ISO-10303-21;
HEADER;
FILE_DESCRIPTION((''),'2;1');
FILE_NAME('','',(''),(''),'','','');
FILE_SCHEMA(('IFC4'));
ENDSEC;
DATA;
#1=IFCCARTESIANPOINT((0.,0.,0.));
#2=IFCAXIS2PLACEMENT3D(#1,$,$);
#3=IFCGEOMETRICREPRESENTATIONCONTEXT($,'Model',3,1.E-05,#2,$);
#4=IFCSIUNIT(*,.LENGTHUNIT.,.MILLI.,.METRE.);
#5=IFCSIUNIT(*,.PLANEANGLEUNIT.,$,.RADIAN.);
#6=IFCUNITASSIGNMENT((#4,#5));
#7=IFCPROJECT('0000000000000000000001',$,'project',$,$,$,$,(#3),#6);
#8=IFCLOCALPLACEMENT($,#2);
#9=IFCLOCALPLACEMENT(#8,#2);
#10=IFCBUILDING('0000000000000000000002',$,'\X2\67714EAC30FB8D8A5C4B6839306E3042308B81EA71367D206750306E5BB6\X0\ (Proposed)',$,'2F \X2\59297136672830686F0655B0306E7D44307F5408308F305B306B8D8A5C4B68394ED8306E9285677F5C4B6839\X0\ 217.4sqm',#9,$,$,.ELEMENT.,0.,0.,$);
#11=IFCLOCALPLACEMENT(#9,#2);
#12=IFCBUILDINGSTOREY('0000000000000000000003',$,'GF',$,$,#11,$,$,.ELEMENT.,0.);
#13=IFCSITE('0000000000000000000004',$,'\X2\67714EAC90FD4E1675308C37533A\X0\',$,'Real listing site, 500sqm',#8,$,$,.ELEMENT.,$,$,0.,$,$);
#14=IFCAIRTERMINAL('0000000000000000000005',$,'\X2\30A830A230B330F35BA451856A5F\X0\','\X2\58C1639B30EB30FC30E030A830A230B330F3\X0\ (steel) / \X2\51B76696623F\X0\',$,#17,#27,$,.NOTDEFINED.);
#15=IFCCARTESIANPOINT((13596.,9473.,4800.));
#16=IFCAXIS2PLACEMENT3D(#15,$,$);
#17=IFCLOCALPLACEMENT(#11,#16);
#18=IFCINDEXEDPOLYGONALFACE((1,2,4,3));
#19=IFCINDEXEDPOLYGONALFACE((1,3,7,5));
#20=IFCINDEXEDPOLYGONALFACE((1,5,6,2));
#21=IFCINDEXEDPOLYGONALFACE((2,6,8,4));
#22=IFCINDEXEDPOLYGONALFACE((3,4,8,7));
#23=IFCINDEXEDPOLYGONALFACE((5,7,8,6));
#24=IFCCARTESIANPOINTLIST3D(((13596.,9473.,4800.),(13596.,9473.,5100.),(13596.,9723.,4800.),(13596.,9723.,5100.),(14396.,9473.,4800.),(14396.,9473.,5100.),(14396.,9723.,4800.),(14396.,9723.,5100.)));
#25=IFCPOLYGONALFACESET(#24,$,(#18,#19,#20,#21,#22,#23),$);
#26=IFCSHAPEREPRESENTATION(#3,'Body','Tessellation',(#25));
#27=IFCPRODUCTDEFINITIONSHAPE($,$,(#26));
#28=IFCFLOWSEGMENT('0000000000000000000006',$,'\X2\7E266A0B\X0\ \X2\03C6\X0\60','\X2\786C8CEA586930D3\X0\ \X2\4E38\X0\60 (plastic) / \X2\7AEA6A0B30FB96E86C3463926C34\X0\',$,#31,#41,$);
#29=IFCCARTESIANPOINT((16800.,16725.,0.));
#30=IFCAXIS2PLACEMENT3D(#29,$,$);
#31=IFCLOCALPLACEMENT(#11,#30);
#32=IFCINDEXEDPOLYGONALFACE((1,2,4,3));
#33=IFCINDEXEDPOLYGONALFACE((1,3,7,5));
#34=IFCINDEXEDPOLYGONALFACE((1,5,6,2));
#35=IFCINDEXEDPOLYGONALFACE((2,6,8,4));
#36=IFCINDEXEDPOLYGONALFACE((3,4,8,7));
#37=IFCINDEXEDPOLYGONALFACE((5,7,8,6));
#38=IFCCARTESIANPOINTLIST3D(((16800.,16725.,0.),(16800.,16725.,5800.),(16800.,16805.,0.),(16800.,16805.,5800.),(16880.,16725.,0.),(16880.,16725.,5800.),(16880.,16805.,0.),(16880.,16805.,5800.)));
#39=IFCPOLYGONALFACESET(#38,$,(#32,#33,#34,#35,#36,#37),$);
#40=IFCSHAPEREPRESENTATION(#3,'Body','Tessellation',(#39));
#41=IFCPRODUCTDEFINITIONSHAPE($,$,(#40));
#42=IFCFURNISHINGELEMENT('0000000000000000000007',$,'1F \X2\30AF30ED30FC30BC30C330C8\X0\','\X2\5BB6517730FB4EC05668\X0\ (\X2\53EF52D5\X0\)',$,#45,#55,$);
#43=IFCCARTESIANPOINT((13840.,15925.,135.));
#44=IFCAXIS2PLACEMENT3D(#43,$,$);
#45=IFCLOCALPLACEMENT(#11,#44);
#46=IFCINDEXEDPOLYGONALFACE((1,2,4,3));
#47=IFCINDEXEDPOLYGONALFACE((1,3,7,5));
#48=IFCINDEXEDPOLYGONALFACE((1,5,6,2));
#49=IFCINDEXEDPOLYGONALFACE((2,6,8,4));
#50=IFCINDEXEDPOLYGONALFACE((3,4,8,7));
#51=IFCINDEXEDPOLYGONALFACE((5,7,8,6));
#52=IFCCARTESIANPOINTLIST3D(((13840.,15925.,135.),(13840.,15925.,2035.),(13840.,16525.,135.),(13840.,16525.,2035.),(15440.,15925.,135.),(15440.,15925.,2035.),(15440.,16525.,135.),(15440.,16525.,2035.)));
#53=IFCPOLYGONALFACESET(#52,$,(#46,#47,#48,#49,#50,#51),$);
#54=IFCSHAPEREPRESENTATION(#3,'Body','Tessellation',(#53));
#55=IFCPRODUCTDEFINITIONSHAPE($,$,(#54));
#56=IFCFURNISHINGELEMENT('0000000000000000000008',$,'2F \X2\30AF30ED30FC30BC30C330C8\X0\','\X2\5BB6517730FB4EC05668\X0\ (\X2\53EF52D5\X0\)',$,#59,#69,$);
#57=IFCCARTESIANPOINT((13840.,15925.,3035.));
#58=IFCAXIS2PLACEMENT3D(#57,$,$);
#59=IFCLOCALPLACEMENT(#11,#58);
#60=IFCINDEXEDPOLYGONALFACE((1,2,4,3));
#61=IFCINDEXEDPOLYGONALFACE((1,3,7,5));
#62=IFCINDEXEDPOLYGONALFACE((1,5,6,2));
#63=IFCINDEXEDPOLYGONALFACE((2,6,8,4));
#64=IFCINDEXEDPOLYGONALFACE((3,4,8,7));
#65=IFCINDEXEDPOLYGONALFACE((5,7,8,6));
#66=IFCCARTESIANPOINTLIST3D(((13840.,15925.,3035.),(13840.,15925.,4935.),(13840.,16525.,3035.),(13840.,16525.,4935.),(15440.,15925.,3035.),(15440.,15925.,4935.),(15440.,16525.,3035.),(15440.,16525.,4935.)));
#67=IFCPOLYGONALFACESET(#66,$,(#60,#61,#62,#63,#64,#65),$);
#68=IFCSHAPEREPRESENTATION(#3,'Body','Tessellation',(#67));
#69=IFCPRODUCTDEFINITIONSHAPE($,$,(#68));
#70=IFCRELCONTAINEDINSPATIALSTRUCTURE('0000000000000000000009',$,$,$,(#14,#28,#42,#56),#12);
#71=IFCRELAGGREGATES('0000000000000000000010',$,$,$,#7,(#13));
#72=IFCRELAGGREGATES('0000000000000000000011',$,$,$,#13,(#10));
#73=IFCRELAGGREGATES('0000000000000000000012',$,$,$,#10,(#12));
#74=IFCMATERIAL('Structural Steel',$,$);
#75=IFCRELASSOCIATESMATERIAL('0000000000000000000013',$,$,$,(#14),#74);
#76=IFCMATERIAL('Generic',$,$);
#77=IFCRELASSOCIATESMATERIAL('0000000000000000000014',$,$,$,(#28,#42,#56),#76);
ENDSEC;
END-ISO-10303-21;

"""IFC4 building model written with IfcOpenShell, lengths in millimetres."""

from ifc_helpers import new_model, si_unit, frame, frame_2d, origin, place, context, project, spatial, rectangle, extrude, material, element, save


model = new_model("IFC4")

# Units and contexts
model_context = context("Model", 3, precision=1e-05, world=origin())
ifc_project = project(units=[si_unit("LENGTHUNIT", "METRE", prefix="MILLI"), si_unit("PLANEANGLEUNIT", "RADIAN")], contexts=[model_context])

# Site, building, storey
site_placement = place(None, origin())
site = spatial("IfcSite", under=ifc_project, at=site_placement, Name="東京都世田谷区", ObjectType="Real listing site, 500sqm", CompositionType="ELEMENT", RefElevation=0.0)
building_placement = place(site_placement, origin())
building = spatial("IfcBuilding", under=site, at=building_placement, Name="東京・越屋根のある自然素材の家 (Proposed)", ObjectType="2F 天然木と漆喰の組み合わせに越屋根付の銅板屋根 217.4sqm", CompositionType="ELEMENT", ElevationOfRefHeight=0.0, ElevationOfTerrain=0.0)
storey_placement = place(building_placement, origin())
storey = spatial("IfcBuildingStorey", under=building, at=storey_placement, Name="GF", CompositionType="ELEMENT", Elevation=0.0)

# Shared definitions
ifc_material_1 = material(Name="Generic")

# Air terminal
ifc_material_2 = material(Name="Structural Steel")
air_terminal_placement = place(storey_placement, frame((13596.0, 9473.0, 4800.0)))
element("IfcAirTerminal", 1, at=air_terminal_placement, inside=storey, material=ifc_material_2, Name="エアコン室内機", Description="壁掛ルームエアコン (steel) / 冷暖房", PredefinedType="NOTDEFINED", context=model_context, shape_type="SweptSolid", body=[
    extrude(rectangle(XDim=800.0, YDim=250.0, at=frame_2d((400.0, 125.0))), frame((13596.0, 9473.0, 4800.0)), (0.0, 0.0, 1.0), 300.0),
])

# Flow segment
flow_segment_placement = place(storey_placement, frame((16800.0, 16725.0, 0.0)))
element("IfcFlowSegment", 2, at=flow_segment_placement, inside=storey, material=ifc_material_1, Name="縦樋 φ60", Description="硬質塩ビ 丸60 (plastic) / 竪樋・雨水排水", context=model_context, shape_type="SweptSolid", body=[
    extrude(rectangle(XDim=80.0, YDim=80.0, at=frame_2d((40.0, 40.0))), frame((16800.0, 16725.0, 0.0)), (0.0, 0.0, 1.0), 5800.0),
])

# Furnishing elements
furnishing_1_placement = place(storey_placement, frame((13840.0, 15925.0, 135.0)))
element("IfcFurnishingElement", 3, at=furnishing_1_placement, inside=storey, material=ifc_material_1, Name="1F クローゼット", Description="家具・什器 (可動)", context=model_context, shape_type="SweptSolid", body=[
    extrude(rectangle(XDim=1600.0, YDim=600.0, at=frame_2d((800.0, 300.0))), frame((13840.0, 15925.0, 135.0)), (0.0, 0.0, 1.0), 1900.0),
])
furnishing_2_placement = place(storey_placement, frame((13840.0, 15925.0, 3035.0)))
element("IfcFurnishingElement", 4, at=furnishing_2_placement, inside=storey, material=ifc_material_1, Name="2F クローゼット", Description="家具・什器 (可動)", context=model_context, shape_type="SweptSolid", body=[
    extrude(rectangle(XDim=1600.0, YDim=600.0, at=frame_2d((800.0, 300.0))), frame((13840.0, 15925.0, 3035.0)), (0.0, 0.0, 1.0), 1900.0),
])

save(model, "model.ifc")
